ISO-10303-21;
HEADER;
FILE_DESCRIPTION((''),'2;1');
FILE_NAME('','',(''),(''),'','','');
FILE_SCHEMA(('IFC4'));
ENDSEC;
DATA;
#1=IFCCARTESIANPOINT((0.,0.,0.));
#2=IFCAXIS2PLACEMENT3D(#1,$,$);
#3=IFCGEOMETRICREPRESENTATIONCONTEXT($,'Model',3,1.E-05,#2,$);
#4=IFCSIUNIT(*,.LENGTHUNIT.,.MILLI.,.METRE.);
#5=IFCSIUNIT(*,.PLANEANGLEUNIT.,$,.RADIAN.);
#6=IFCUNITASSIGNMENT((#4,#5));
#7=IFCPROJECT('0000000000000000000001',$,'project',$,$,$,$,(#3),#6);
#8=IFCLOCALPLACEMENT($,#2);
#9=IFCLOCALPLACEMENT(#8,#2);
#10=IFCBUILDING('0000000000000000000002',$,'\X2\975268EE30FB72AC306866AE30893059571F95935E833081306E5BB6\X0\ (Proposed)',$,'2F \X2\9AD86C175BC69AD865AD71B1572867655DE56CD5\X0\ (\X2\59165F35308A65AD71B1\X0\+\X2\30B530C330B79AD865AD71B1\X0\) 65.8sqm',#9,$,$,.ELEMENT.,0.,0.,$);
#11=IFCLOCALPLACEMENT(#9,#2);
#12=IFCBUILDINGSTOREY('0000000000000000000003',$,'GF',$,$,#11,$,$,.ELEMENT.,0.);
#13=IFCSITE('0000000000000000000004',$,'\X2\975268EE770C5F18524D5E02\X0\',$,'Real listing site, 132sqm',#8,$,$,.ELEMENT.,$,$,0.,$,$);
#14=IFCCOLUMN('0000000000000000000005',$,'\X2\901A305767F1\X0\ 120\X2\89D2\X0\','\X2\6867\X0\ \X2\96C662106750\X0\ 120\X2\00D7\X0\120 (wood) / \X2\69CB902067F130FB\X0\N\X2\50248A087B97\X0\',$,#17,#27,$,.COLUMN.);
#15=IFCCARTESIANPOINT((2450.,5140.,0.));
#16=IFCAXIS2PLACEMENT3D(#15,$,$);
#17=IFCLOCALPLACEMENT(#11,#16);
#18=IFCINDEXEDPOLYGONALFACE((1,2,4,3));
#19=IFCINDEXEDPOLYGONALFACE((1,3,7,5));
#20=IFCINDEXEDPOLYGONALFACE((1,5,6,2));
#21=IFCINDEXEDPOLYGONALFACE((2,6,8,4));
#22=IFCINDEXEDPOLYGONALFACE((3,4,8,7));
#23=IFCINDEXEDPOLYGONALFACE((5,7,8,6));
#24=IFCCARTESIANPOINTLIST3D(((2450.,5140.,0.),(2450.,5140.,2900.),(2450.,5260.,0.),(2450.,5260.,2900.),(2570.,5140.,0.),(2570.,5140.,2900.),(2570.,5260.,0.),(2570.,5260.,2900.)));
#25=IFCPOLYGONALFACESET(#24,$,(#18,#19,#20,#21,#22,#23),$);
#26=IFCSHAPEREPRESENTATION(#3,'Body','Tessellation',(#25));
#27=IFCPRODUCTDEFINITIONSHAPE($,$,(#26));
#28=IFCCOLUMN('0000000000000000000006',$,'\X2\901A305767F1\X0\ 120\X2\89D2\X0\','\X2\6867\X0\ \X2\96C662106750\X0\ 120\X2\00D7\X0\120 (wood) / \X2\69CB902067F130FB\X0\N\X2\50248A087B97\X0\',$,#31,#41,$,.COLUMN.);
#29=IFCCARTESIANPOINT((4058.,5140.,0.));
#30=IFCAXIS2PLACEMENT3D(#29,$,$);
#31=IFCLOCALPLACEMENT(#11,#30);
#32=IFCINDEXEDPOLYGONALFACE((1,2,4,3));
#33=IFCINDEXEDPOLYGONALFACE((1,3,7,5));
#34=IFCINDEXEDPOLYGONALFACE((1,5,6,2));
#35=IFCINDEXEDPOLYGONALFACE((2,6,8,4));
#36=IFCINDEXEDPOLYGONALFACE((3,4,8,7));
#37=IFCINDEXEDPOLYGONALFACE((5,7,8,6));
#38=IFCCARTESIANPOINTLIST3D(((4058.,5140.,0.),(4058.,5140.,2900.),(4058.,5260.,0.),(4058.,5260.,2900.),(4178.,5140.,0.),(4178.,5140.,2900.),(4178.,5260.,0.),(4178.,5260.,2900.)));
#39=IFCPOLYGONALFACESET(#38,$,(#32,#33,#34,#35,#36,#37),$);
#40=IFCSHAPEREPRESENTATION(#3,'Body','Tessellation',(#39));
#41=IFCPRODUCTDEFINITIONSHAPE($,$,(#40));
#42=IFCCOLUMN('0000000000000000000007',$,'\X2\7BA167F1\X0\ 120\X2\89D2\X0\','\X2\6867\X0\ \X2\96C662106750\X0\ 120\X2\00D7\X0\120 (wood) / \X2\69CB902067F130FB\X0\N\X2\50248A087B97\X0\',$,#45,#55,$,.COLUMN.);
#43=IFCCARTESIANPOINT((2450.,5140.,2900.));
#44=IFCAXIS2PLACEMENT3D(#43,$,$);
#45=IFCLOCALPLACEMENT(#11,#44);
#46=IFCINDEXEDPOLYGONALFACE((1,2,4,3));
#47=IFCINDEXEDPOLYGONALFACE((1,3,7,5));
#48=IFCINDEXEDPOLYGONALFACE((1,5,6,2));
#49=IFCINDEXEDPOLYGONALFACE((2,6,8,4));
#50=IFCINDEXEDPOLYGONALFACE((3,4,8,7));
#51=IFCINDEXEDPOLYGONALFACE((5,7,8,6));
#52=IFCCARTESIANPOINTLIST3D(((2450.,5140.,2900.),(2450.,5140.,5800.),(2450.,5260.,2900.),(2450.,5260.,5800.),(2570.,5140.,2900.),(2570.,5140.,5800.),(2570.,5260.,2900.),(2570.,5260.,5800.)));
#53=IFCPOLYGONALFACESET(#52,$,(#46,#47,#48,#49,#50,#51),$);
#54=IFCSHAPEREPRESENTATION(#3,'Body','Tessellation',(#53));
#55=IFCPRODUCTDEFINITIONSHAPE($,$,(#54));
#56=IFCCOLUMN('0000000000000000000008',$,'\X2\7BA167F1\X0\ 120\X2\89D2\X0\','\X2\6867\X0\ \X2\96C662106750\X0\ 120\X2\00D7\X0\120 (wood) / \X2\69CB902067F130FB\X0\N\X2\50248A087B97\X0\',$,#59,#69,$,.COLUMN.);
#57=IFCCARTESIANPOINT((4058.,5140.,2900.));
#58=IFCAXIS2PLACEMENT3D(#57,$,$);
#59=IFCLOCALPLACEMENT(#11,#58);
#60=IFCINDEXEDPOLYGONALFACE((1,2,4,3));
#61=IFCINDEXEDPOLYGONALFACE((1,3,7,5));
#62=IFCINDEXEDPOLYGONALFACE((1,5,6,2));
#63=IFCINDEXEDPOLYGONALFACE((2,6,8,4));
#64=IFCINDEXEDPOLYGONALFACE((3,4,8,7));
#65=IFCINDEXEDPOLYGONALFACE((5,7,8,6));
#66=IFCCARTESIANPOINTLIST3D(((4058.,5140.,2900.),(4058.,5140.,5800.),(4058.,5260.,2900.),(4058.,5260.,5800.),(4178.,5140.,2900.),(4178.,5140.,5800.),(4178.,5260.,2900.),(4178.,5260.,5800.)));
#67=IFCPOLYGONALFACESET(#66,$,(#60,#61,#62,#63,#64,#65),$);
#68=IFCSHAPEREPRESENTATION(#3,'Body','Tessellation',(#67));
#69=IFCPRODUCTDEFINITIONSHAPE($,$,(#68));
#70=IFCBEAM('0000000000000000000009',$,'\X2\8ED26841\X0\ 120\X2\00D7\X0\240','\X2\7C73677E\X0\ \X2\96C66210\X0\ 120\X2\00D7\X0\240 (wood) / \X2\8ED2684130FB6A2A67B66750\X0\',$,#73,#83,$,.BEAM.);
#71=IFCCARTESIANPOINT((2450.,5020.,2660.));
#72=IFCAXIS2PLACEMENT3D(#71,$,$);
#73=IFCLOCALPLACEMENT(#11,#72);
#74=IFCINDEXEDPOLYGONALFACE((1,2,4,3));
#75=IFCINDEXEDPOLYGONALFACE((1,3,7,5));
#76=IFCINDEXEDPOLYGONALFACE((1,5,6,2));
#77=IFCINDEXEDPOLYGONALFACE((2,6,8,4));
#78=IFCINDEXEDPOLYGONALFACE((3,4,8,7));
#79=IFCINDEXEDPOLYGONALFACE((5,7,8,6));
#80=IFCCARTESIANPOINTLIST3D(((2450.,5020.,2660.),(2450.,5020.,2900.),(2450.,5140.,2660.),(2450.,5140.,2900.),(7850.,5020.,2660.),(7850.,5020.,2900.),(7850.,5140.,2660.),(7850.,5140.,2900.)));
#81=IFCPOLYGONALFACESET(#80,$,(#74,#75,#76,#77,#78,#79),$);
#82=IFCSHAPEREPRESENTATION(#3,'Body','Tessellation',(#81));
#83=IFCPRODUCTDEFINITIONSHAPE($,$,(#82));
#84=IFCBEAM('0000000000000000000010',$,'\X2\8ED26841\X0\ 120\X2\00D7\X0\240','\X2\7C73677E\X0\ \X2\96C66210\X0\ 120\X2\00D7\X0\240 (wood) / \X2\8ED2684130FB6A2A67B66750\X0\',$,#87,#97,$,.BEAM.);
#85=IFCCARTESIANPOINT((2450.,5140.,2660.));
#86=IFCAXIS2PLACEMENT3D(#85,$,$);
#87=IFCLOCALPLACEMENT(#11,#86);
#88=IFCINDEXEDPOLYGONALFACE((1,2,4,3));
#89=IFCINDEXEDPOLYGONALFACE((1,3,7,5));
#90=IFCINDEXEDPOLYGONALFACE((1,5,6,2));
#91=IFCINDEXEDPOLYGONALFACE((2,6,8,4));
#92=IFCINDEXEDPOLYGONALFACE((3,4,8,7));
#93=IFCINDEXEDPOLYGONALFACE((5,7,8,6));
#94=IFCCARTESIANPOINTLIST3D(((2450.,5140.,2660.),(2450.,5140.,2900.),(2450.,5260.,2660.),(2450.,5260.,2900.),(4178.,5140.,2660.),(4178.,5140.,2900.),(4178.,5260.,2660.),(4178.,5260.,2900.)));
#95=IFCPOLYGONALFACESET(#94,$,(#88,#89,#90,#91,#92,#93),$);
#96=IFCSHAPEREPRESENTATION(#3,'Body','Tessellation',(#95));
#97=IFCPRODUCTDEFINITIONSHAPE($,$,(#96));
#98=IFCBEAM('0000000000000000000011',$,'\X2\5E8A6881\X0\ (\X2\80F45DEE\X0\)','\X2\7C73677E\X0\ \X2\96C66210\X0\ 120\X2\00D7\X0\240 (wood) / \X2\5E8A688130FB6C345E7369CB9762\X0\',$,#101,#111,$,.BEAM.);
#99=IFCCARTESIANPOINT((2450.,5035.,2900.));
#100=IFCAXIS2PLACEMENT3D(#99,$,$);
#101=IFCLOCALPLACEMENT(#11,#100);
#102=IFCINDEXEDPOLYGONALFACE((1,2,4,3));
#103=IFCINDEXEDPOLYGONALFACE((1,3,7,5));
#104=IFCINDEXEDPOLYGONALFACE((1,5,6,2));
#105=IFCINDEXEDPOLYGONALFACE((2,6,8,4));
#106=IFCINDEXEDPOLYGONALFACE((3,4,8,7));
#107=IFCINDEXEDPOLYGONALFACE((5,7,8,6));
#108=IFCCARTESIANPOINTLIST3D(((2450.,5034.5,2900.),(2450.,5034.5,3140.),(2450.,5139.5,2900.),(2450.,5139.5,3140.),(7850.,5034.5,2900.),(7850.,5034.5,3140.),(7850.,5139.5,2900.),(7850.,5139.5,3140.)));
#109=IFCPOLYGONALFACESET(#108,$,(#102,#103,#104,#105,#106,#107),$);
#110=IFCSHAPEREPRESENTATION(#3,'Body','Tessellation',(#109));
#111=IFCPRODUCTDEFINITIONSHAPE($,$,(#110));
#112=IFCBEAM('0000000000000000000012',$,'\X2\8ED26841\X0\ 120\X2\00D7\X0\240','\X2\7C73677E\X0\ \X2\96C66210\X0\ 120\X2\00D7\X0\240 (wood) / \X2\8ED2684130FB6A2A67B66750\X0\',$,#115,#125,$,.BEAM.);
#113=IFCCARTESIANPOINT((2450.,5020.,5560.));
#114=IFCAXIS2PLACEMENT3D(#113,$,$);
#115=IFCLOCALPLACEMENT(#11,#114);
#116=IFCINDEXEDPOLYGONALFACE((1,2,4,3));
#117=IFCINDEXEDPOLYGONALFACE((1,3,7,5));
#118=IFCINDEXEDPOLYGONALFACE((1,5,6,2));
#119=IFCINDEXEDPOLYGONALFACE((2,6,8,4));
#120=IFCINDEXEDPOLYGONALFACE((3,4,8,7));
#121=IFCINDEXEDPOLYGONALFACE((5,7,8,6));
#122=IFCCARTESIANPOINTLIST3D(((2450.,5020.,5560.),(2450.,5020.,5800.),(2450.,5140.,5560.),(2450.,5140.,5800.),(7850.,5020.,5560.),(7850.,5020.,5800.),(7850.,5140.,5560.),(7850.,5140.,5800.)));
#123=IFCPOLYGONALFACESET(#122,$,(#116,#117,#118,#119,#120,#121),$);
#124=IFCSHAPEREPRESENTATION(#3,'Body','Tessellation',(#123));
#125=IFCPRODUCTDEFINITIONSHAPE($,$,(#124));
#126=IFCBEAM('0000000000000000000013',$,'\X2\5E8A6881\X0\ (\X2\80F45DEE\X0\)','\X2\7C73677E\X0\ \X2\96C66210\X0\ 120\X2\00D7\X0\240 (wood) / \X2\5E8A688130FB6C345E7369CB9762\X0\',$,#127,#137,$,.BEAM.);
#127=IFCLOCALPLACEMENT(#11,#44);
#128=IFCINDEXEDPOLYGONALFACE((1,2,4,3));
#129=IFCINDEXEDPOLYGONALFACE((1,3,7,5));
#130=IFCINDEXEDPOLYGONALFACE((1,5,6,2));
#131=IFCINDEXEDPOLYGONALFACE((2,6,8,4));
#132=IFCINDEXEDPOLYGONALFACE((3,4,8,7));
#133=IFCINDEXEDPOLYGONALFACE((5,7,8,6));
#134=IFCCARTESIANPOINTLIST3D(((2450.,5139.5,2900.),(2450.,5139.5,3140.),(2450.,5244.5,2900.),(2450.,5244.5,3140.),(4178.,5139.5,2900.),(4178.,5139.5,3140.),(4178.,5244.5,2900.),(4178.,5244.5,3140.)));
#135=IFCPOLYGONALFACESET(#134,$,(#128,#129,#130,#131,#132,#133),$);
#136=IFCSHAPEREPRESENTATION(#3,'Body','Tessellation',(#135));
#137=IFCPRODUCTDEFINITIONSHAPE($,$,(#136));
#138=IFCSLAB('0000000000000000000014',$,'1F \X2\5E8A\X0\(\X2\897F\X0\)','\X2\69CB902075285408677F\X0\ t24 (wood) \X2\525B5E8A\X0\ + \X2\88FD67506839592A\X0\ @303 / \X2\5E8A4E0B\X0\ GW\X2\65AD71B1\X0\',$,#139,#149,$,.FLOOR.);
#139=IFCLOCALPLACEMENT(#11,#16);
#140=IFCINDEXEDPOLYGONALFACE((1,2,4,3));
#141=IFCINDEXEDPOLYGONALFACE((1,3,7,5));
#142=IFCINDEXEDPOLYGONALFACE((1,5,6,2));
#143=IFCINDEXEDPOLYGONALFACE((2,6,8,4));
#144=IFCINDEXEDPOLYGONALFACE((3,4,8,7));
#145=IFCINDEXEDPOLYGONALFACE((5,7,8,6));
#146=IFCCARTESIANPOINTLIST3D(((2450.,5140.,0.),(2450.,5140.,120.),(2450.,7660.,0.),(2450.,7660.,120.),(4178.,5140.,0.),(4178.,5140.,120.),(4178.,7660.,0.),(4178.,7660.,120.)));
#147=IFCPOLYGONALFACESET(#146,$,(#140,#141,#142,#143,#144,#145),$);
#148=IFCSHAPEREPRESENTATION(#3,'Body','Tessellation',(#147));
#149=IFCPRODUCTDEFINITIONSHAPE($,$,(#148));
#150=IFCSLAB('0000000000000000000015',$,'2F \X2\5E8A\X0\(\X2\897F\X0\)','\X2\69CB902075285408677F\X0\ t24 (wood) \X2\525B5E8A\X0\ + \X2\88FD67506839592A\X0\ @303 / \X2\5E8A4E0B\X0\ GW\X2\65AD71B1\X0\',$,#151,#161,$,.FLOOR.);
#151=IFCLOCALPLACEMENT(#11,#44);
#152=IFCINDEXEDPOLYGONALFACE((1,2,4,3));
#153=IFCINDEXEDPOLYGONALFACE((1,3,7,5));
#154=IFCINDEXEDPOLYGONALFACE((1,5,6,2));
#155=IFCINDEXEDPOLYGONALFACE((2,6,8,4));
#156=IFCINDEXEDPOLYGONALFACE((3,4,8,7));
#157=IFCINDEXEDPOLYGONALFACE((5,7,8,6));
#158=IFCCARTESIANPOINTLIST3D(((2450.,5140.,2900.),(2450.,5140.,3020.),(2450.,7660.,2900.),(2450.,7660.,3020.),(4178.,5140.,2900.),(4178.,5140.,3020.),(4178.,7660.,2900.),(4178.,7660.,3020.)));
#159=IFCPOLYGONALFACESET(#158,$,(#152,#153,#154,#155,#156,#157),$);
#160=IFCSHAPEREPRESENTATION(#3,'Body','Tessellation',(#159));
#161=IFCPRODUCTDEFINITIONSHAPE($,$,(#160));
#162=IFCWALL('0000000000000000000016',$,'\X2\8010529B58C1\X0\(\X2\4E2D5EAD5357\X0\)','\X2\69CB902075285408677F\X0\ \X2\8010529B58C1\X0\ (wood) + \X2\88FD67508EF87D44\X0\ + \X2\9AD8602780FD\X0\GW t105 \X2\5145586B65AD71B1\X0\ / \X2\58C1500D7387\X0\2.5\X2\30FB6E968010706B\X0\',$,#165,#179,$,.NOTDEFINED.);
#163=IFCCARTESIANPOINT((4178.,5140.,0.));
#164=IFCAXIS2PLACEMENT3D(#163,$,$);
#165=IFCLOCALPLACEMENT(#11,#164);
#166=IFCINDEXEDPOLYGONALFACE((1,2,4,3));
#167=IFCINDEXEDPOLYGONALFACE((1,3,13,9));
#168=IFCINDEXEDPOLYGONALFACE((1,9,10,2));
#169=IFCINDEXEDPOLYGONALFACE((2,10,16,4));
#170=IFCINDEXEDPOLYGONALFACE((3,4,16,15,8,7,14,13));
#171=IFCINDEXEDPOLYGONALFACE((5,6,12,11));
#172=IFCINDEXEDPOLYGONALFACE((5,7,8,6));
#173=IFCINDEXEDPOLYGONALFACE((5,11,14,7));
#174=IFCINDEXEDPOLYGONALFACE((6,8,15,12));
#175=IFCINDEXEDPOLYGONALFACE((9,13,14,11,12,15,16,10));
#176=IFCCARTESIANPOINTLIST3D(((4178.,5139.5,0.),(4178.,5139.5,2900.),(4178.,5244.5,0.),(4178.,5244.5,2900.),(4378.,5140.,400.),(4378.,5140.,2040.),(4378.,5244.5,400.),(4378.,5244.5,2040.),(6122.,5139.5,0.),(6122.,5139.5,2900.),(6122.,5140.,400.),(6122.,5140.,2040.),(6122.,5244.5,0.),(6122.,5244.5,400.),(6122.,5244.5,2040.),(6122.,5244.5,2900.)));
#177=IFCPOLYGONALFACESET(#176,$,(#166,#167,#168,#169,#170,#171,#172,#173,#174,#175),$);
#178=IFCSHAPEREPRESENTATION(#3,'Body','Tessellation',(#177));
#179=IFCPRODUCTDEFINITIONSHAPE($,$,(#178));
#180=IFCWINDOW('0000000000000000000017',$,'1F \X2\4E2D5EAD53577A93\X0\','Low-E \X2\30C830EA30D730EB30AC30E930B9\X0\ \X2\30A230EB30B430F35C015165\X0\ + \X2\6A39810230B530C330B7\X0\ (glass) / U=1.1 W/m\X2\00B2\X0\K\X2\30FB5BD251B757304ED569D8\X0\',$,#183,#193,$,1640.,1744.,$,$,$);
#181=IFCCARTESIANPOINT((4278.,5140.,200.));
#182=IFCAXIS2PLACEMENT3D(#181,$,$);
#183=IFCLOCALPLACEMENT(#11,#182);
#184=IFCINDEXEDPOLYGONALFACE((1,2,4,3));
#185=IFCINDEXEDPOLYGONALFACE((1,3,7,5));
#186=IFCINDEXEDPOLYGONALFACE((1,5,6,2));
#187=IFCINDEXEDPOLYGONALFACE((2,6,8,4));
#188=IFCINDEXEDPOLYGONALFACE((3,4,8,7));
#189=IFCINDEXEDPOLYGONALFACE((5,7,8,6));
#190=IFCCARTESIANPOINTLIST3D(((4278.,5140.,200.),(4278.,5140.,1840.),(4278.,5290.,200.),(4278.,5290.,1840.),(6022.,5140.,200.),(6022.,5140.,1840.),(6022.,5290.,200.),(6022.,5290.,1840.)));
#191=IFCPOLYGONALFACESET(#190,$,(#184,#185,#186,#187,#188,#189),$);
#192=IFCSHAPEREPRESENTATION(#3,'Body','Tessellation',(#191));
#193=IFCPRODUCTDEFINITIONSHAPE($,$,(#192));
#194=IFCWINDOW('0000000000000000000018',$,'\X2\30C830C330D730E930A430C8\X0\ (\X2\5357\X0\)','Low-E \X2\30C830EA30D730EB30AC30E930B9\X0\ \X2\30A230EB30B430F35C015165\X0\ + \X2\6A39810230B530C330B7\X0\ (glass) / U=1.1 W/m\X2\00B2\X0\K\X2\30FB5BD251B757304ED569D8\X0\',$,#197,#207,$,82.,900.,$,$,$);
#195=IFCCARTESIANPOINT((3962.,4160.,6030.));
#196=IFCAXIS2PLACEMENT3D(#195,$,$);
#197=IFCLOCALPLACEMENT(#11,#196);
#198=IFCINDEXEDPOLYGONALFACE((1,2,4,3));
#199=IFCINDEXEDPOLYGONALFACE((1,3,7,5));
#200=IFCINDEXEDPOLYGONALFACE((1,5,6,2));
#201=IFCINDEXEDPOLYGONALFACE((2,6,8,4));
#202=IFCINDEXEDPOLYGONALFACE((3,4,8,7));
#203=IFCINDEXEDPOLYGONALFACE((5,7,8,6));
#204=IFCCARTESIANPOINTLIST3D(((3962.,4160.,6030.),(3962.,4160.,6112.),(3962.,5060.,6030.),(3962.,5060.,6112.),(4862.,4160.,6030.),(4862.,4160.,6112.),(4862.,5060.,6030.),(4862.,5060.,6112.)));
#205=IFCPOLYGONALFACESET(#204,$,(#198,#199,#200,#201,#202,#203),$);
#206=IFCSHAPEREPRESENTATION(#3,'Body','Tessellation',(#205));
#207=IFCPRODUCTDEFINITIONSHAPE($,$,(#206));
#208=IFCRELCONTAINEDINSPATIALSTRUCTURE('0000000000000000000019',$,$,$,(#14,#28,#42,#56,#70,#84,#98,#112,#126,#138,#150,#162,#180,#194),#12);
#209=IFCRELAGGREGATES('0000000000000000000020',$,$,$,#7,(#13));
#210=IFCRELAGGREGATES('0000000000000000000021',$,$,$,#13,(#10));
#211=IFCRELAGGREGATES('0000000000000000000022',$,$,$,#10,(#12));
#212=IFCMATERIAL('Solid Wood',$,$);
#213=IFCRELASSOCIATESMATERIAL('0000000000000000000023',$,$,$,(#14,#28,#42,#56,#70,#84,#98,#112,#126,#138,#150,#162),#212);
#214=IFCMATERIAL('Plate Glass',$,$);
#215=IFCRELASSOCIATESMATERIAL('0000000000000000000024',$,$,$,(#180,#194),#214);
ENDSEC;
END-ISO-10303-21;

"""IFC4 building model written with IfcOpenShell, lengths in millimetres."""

from ifc_helpers import new_model, si_unit, frame, frame_2d, origin, place, context, project, spatial, rectangle, extrude, material, element, fill, save


model = new_model("IFC4")

# Units and contexts
model_context = context("Model", 3, precision=1e-05, world=origin())
ifc_project = project(units=[si_unit("LENGTHUNIT", "METRE", prefix="MILLI"), si_unit("PLANEANGLEUNIT", "RADIAN")], contexts=[model_context])

# Site, building, storey
site_placement = place(None, origin())
site = spatial("IfcSite", under=ifc_project, at=site_placement, Name="青森県弘前市", ObjectType="Real listing site, 132sqm", CompositionType="ELEMENT", RefElevation=0.0)
building_placement = place(site_placement, origin())
building = spatial("IfcBuilding", under=site, at=building_placement, Name="青森・犬と暮らす土間広めの家 (Proposed)", ObjectType="2F 高気密高断熱在来工法 (外張り断熱+サッシ高断熱) 65.8sqm", CompositionType="ELEMENT", ElevationOfRefHeight=0.0, ElevationOfTerrain=0.0)
storey_placement = place(building_placement, origin())
storey = spatial("IfcBuildingStorey", under=building, at=storey_placement, Name="GF", CompositionType="ELEMENT", Elevation=0.0)

# Columns
ifc_material_1 = material(Name="Solid Wood")
column_1_placement = place(storey_placement, frame((2450.0, 5140.0, 0.0)))
element("IfcColumn", 1, at=column_1_placement, inside=storey, material=ifc_material_1, Name="通し柱 120角", Description="桧 集成材 120×120 (wood) / 構造柱・N値計算", PredefinedType="COLUMN", context=model_context, shape_type="SweptSolid", body=[
    extrude(rectangle(XDim=120.0, YDim=120.0, at=frame_2d((60.0, 60.0))), frame((2450.0, 5140.0, 0.0)), (0.0, 0.0, 1.0), 2900.0),
])
column_2_placement = place(storey_placement, frame((4058.0, 5140.0, 0.0)))
element("IfcColumn", 2, at=column_2_placement, inside=storey, material=ifc_material_1, Name="通し柱 120角", Description="桧 集成材 120×120 (wood) / 構造柱・N値計算", PredefinedType="COLUMN", context=model_context, shape_type="SweptSolid", body=[
    extrude(rectangle(XDim=120.0, YDim=120.0, at=frame_2d((60.0, 60.0))), frame((4058.0, 5140.0, 0.0)), (0.0, 0.0, 1.0), 2900.0),
])
column_3_placement = place(storey_placement, frame((2450.0, 5140.0, 2900.0)))
element("IfcColumn", 3, at=column_3_placement, inside=storey, material=ifc_material_1, Name="管柱 120角", Description="桧 集成材 120×120 (wood) / 構造柱・N値計算", PredefinedType="COLUMN", context=model_context, shape_type="SweptSolid", body=[
    extrude(rectangle(XDim=120.0, YDim=120.0, at=frame_2d((60.0, 60.0))), frame((2450.0, 5140.0, 2900.0)), (0.0, 0.0, 1.0), 2900.0),
])
column_4_placement = place(storey_placement, frame((4058.0, 5140.0, 2900.0)))
element("IfcColumn", 4, at=column_4_placement, inside=storey, material=ifc_material_1, Name="管柱 120角", Description="桧 集成材 120×120 (wood) / 構造柱・N値計算", PredefinedType="COLUMN", context=model_context, shape_type="SweptSolid", body=[
    extrude(rectangle(XDim=120.0, YDim=120.0, at=frame_2d((60.0, 60.0))), frame((4058.0, 5140.0, 2900.0)), (0.0, 0.0, 1.0), 2900.0),
])

# Beams
beam_1_placement = place(storey_placement, frame((2450.0, 5020.0, 2660.0)))
element("IfcBeam", 5, at=beam_1_placement, inside=storey, material=ifc_material_1, Name="軒桁 120×240", Description="米松 集成 120×240 (wood) / 軒桁・横架材", PredefinedType="BEAM", context=model_context, shape_type="SweptSolid", body=[
    extrude(rectangle(XDim=5400.0, YDim=120.0, at=frame_2d((2700.0, 60.0))), frame((2450.0, 5020.0, 2660.0)), (0.0, 0.0, 1.0), 240.0),
])
beam_2_placement = place(storey_placement, frame((2450.0, 5140.0, 2660.0)))
element("IfcBeam", 6, at=beam_2_placement, inside=storey, material=ifc_material_1, Name="軒桁 120×240", Description="米松 集成 120×240 (wood) / 軒桁・横架材", PredefinedType="BEAM", context=model_context, shape_type="SweptSolid", body=[
    extrude(rectangle(XDim=1728.0, YDim=120.0, at=frame_2d((864.0, 60.0))), frame((2450.0, 5140.0, 2660.0)), (0.0, 0.0, 1.0), 240.0),
])
beam_3_placement = place(storey_placement, frame((2450.0, 5035.0, 2900.0)))
element("IfcBeam", 7, at=beam_3_placement, inside=storey, material=ifc_material_1, Name="床梁 (胴差)", Description="米松 集成 120×240 (wood) / 床梁・水平構面", PredefinedType="BEAM", context=model_context, shape_type="SweptSolid", body=[
    extrude(rectangle(XDim=5400.0, YDim=105.0, at=frame_2d((2700.0, 52.0))), frame((2450.0, 5035.0, 2900.0)), (0.0, 0.0, 1.0), 240.0),
])
beam_4_placement = place(storey_placement, frame((2450.0, 5020.0, 5560.0)))
element("IfcBeam", 8, at=beam_4_placement, inside=storey, material=ifc_material_1, Name="軒桁 120×240", Description="米松 集成 120×240 (wood) / 軒桁・横架材", PredefinedType="BEAM", context=model_context, shape_type="SweptSolid", body=[
    extrude(rectangle(XDim=5400.0, YDim=120.0, at=frame_2d((2700.0, 60.0))), frame((2450.0, 5020.0, 5560.0)), (0.0, 0.0, 1.0), 240.0),
])
beam_5_placement = place(storey_placement, frame((2450.0, 5140.0, 2900.0)))
element("IfcBeam", 9, at=beam_5_placement, inside=storey, material=ifc_material_1, Name="床梁 (胴差)", Description="米松 集成 120×240 (wood) / 床梁・水平構面", PredefinedType="BEAM", context=model_context, shape_type="SweptSolid", body=[
    extrude(rectangle(XDim=1728.0, YDim=105.0, at=frame_2d((864.0, 52.0))), frame((2450.0, 5140.0, 2900.0)), (0.0, 0.0, 1.0), 240.0),
])

# Slabs
slab_1_placement = place(storey_placement, frame((2450.0, 5140.0, 0.0)))
element("IfcSlab", 10, at=slab_1_placement, inside=storey, material=ifc_material_1, Name="1F 床(西)", Description="構造用合板 t24 (wood) 剛床 + 製材根太 @303 / 床下 GW断熱", PredefinedType="FLOOR", context=model_context, shape_type="SweptSolid", body=[
    extrude(rectangle(XDim=1728.0, YDim=2520.0, at=frame_2d((864.0, 1260.0))), frame((2450.0, 5140.0, 0.0)), (0.0, 0.0, 1.0), 120.0),
])
slab_2_placement = place(storey_placement, frame((2450.0, 5140.0, 2900.0)))
element("IfcSlab", 11, at=slab_2_placement, inside=storey, material=ifc_material_1, Name="2F 床(西)", Description="構造用合板 t24 (wood) 剛床 + 製材根太 @303 / 床下 GW断熱", PredefinedType="FLOOR", context=model_context, shape_type="SweptSolid", body=[
    extrude(rectangle(XDim=1728.0, YDim=2520.0, at=frame_2d((864.0, 1260.0))), frame((2450.0, 5140.0, 2900.0)), (0.0, 0.0, 1.0), 120.0),
])

# Wall, opening, window
wall_1_placement = place(storey_placement, frame((4178.0, 5140.0, 0.0)))
wall_1 = element("IfcWall", 12, at=wall_1_placement, inside=storey, material=ifc_material_1, Name="耐力壁(中庭南)", Description="構造用合板 耐力壁 (wood) + 製材軸組 + 高性能GW t105 充填断熱 / 壁倍率2.5・準耐火", PredefinedType="NOTDEFINED", context=model_context, shape_type="SweptSolid", body=[
    extrude(rectangle(XDim=1944.0, YDim=105.0, at=frame_2d((972.0, 52.0))), frame((4178.0, 5140.0, 0.0)), (0.0, 0.0, 1.0), 2900.0),
])
opening_placement = place(storey_placement, frame((4278.0, 5140.0, 200.0)))
opening = element("IfcOpeningElement", 13, at=opening_placement, cuts=wall_1, PredefinedType="NOTDEFINED", context=model_context, shape_type="SweptSolid", body=[
    extrude(rectangle(XDim=1744.0, YDim=150.0, at=frame_2d((872.0, 75.0))), frame((4278.0, 5140.0, 200.0)), (0.0, 0.0, 1.0), 1640.0),
])
ifc_material_2 = material(Name="Plate Glass")
window_1_placement = place(storey_placement, frame((4278.0, 5140.0, 200.0)))
window_1 = element("IfcWindow", 14, at=window_1_placement, inside=storey, material=ifc_material_2, Name="1F 中庭南窓", Description="Low-E トリプルガラス アルゴン封入 + 樹脂サッシ (glass) / U=1.1 W/m²K・寒冷地仕様", OverallHeight=1640.0, OverallWidth=1744.0, context=model_context, shape_type="SweptSolid", body=[
    extrude(rectangle(XDim=1744.0, YDim=150.0, at=frame_2d((872.0, 75.0))), frame((4278.0, 5140.0, 200.0)), (0.0, 0.0, 1.0), 1640.0),
])
fill(opening, window_1)

# Window
window_2_placement = place(storey_placement, frame((3962.0, 4160.0, 6030.0)))
element("IfcWindow", 15, at=window_2_placement, inside=storey, material=ifc_material_2, Name="トップライト (南)", Description="Low-E トリプルガラス アルゴン封入 + 樹脂サッシ (glass) / U=1.1 W/m²K・寒冷地仕様", OverallHeight=82.0, OverallWidth=900.0, context=model_context, shape_type="SweptSolid", body=[
    extrude(rectangle(XDim=900.0, YDim=900.0, at=frame_2d((450.0, 450.0))), frame((3962.0, 4160.0, 6030.0)), (0.0, 0.0, 1.0), 82.0),
])

save(model, "model.ifc")
